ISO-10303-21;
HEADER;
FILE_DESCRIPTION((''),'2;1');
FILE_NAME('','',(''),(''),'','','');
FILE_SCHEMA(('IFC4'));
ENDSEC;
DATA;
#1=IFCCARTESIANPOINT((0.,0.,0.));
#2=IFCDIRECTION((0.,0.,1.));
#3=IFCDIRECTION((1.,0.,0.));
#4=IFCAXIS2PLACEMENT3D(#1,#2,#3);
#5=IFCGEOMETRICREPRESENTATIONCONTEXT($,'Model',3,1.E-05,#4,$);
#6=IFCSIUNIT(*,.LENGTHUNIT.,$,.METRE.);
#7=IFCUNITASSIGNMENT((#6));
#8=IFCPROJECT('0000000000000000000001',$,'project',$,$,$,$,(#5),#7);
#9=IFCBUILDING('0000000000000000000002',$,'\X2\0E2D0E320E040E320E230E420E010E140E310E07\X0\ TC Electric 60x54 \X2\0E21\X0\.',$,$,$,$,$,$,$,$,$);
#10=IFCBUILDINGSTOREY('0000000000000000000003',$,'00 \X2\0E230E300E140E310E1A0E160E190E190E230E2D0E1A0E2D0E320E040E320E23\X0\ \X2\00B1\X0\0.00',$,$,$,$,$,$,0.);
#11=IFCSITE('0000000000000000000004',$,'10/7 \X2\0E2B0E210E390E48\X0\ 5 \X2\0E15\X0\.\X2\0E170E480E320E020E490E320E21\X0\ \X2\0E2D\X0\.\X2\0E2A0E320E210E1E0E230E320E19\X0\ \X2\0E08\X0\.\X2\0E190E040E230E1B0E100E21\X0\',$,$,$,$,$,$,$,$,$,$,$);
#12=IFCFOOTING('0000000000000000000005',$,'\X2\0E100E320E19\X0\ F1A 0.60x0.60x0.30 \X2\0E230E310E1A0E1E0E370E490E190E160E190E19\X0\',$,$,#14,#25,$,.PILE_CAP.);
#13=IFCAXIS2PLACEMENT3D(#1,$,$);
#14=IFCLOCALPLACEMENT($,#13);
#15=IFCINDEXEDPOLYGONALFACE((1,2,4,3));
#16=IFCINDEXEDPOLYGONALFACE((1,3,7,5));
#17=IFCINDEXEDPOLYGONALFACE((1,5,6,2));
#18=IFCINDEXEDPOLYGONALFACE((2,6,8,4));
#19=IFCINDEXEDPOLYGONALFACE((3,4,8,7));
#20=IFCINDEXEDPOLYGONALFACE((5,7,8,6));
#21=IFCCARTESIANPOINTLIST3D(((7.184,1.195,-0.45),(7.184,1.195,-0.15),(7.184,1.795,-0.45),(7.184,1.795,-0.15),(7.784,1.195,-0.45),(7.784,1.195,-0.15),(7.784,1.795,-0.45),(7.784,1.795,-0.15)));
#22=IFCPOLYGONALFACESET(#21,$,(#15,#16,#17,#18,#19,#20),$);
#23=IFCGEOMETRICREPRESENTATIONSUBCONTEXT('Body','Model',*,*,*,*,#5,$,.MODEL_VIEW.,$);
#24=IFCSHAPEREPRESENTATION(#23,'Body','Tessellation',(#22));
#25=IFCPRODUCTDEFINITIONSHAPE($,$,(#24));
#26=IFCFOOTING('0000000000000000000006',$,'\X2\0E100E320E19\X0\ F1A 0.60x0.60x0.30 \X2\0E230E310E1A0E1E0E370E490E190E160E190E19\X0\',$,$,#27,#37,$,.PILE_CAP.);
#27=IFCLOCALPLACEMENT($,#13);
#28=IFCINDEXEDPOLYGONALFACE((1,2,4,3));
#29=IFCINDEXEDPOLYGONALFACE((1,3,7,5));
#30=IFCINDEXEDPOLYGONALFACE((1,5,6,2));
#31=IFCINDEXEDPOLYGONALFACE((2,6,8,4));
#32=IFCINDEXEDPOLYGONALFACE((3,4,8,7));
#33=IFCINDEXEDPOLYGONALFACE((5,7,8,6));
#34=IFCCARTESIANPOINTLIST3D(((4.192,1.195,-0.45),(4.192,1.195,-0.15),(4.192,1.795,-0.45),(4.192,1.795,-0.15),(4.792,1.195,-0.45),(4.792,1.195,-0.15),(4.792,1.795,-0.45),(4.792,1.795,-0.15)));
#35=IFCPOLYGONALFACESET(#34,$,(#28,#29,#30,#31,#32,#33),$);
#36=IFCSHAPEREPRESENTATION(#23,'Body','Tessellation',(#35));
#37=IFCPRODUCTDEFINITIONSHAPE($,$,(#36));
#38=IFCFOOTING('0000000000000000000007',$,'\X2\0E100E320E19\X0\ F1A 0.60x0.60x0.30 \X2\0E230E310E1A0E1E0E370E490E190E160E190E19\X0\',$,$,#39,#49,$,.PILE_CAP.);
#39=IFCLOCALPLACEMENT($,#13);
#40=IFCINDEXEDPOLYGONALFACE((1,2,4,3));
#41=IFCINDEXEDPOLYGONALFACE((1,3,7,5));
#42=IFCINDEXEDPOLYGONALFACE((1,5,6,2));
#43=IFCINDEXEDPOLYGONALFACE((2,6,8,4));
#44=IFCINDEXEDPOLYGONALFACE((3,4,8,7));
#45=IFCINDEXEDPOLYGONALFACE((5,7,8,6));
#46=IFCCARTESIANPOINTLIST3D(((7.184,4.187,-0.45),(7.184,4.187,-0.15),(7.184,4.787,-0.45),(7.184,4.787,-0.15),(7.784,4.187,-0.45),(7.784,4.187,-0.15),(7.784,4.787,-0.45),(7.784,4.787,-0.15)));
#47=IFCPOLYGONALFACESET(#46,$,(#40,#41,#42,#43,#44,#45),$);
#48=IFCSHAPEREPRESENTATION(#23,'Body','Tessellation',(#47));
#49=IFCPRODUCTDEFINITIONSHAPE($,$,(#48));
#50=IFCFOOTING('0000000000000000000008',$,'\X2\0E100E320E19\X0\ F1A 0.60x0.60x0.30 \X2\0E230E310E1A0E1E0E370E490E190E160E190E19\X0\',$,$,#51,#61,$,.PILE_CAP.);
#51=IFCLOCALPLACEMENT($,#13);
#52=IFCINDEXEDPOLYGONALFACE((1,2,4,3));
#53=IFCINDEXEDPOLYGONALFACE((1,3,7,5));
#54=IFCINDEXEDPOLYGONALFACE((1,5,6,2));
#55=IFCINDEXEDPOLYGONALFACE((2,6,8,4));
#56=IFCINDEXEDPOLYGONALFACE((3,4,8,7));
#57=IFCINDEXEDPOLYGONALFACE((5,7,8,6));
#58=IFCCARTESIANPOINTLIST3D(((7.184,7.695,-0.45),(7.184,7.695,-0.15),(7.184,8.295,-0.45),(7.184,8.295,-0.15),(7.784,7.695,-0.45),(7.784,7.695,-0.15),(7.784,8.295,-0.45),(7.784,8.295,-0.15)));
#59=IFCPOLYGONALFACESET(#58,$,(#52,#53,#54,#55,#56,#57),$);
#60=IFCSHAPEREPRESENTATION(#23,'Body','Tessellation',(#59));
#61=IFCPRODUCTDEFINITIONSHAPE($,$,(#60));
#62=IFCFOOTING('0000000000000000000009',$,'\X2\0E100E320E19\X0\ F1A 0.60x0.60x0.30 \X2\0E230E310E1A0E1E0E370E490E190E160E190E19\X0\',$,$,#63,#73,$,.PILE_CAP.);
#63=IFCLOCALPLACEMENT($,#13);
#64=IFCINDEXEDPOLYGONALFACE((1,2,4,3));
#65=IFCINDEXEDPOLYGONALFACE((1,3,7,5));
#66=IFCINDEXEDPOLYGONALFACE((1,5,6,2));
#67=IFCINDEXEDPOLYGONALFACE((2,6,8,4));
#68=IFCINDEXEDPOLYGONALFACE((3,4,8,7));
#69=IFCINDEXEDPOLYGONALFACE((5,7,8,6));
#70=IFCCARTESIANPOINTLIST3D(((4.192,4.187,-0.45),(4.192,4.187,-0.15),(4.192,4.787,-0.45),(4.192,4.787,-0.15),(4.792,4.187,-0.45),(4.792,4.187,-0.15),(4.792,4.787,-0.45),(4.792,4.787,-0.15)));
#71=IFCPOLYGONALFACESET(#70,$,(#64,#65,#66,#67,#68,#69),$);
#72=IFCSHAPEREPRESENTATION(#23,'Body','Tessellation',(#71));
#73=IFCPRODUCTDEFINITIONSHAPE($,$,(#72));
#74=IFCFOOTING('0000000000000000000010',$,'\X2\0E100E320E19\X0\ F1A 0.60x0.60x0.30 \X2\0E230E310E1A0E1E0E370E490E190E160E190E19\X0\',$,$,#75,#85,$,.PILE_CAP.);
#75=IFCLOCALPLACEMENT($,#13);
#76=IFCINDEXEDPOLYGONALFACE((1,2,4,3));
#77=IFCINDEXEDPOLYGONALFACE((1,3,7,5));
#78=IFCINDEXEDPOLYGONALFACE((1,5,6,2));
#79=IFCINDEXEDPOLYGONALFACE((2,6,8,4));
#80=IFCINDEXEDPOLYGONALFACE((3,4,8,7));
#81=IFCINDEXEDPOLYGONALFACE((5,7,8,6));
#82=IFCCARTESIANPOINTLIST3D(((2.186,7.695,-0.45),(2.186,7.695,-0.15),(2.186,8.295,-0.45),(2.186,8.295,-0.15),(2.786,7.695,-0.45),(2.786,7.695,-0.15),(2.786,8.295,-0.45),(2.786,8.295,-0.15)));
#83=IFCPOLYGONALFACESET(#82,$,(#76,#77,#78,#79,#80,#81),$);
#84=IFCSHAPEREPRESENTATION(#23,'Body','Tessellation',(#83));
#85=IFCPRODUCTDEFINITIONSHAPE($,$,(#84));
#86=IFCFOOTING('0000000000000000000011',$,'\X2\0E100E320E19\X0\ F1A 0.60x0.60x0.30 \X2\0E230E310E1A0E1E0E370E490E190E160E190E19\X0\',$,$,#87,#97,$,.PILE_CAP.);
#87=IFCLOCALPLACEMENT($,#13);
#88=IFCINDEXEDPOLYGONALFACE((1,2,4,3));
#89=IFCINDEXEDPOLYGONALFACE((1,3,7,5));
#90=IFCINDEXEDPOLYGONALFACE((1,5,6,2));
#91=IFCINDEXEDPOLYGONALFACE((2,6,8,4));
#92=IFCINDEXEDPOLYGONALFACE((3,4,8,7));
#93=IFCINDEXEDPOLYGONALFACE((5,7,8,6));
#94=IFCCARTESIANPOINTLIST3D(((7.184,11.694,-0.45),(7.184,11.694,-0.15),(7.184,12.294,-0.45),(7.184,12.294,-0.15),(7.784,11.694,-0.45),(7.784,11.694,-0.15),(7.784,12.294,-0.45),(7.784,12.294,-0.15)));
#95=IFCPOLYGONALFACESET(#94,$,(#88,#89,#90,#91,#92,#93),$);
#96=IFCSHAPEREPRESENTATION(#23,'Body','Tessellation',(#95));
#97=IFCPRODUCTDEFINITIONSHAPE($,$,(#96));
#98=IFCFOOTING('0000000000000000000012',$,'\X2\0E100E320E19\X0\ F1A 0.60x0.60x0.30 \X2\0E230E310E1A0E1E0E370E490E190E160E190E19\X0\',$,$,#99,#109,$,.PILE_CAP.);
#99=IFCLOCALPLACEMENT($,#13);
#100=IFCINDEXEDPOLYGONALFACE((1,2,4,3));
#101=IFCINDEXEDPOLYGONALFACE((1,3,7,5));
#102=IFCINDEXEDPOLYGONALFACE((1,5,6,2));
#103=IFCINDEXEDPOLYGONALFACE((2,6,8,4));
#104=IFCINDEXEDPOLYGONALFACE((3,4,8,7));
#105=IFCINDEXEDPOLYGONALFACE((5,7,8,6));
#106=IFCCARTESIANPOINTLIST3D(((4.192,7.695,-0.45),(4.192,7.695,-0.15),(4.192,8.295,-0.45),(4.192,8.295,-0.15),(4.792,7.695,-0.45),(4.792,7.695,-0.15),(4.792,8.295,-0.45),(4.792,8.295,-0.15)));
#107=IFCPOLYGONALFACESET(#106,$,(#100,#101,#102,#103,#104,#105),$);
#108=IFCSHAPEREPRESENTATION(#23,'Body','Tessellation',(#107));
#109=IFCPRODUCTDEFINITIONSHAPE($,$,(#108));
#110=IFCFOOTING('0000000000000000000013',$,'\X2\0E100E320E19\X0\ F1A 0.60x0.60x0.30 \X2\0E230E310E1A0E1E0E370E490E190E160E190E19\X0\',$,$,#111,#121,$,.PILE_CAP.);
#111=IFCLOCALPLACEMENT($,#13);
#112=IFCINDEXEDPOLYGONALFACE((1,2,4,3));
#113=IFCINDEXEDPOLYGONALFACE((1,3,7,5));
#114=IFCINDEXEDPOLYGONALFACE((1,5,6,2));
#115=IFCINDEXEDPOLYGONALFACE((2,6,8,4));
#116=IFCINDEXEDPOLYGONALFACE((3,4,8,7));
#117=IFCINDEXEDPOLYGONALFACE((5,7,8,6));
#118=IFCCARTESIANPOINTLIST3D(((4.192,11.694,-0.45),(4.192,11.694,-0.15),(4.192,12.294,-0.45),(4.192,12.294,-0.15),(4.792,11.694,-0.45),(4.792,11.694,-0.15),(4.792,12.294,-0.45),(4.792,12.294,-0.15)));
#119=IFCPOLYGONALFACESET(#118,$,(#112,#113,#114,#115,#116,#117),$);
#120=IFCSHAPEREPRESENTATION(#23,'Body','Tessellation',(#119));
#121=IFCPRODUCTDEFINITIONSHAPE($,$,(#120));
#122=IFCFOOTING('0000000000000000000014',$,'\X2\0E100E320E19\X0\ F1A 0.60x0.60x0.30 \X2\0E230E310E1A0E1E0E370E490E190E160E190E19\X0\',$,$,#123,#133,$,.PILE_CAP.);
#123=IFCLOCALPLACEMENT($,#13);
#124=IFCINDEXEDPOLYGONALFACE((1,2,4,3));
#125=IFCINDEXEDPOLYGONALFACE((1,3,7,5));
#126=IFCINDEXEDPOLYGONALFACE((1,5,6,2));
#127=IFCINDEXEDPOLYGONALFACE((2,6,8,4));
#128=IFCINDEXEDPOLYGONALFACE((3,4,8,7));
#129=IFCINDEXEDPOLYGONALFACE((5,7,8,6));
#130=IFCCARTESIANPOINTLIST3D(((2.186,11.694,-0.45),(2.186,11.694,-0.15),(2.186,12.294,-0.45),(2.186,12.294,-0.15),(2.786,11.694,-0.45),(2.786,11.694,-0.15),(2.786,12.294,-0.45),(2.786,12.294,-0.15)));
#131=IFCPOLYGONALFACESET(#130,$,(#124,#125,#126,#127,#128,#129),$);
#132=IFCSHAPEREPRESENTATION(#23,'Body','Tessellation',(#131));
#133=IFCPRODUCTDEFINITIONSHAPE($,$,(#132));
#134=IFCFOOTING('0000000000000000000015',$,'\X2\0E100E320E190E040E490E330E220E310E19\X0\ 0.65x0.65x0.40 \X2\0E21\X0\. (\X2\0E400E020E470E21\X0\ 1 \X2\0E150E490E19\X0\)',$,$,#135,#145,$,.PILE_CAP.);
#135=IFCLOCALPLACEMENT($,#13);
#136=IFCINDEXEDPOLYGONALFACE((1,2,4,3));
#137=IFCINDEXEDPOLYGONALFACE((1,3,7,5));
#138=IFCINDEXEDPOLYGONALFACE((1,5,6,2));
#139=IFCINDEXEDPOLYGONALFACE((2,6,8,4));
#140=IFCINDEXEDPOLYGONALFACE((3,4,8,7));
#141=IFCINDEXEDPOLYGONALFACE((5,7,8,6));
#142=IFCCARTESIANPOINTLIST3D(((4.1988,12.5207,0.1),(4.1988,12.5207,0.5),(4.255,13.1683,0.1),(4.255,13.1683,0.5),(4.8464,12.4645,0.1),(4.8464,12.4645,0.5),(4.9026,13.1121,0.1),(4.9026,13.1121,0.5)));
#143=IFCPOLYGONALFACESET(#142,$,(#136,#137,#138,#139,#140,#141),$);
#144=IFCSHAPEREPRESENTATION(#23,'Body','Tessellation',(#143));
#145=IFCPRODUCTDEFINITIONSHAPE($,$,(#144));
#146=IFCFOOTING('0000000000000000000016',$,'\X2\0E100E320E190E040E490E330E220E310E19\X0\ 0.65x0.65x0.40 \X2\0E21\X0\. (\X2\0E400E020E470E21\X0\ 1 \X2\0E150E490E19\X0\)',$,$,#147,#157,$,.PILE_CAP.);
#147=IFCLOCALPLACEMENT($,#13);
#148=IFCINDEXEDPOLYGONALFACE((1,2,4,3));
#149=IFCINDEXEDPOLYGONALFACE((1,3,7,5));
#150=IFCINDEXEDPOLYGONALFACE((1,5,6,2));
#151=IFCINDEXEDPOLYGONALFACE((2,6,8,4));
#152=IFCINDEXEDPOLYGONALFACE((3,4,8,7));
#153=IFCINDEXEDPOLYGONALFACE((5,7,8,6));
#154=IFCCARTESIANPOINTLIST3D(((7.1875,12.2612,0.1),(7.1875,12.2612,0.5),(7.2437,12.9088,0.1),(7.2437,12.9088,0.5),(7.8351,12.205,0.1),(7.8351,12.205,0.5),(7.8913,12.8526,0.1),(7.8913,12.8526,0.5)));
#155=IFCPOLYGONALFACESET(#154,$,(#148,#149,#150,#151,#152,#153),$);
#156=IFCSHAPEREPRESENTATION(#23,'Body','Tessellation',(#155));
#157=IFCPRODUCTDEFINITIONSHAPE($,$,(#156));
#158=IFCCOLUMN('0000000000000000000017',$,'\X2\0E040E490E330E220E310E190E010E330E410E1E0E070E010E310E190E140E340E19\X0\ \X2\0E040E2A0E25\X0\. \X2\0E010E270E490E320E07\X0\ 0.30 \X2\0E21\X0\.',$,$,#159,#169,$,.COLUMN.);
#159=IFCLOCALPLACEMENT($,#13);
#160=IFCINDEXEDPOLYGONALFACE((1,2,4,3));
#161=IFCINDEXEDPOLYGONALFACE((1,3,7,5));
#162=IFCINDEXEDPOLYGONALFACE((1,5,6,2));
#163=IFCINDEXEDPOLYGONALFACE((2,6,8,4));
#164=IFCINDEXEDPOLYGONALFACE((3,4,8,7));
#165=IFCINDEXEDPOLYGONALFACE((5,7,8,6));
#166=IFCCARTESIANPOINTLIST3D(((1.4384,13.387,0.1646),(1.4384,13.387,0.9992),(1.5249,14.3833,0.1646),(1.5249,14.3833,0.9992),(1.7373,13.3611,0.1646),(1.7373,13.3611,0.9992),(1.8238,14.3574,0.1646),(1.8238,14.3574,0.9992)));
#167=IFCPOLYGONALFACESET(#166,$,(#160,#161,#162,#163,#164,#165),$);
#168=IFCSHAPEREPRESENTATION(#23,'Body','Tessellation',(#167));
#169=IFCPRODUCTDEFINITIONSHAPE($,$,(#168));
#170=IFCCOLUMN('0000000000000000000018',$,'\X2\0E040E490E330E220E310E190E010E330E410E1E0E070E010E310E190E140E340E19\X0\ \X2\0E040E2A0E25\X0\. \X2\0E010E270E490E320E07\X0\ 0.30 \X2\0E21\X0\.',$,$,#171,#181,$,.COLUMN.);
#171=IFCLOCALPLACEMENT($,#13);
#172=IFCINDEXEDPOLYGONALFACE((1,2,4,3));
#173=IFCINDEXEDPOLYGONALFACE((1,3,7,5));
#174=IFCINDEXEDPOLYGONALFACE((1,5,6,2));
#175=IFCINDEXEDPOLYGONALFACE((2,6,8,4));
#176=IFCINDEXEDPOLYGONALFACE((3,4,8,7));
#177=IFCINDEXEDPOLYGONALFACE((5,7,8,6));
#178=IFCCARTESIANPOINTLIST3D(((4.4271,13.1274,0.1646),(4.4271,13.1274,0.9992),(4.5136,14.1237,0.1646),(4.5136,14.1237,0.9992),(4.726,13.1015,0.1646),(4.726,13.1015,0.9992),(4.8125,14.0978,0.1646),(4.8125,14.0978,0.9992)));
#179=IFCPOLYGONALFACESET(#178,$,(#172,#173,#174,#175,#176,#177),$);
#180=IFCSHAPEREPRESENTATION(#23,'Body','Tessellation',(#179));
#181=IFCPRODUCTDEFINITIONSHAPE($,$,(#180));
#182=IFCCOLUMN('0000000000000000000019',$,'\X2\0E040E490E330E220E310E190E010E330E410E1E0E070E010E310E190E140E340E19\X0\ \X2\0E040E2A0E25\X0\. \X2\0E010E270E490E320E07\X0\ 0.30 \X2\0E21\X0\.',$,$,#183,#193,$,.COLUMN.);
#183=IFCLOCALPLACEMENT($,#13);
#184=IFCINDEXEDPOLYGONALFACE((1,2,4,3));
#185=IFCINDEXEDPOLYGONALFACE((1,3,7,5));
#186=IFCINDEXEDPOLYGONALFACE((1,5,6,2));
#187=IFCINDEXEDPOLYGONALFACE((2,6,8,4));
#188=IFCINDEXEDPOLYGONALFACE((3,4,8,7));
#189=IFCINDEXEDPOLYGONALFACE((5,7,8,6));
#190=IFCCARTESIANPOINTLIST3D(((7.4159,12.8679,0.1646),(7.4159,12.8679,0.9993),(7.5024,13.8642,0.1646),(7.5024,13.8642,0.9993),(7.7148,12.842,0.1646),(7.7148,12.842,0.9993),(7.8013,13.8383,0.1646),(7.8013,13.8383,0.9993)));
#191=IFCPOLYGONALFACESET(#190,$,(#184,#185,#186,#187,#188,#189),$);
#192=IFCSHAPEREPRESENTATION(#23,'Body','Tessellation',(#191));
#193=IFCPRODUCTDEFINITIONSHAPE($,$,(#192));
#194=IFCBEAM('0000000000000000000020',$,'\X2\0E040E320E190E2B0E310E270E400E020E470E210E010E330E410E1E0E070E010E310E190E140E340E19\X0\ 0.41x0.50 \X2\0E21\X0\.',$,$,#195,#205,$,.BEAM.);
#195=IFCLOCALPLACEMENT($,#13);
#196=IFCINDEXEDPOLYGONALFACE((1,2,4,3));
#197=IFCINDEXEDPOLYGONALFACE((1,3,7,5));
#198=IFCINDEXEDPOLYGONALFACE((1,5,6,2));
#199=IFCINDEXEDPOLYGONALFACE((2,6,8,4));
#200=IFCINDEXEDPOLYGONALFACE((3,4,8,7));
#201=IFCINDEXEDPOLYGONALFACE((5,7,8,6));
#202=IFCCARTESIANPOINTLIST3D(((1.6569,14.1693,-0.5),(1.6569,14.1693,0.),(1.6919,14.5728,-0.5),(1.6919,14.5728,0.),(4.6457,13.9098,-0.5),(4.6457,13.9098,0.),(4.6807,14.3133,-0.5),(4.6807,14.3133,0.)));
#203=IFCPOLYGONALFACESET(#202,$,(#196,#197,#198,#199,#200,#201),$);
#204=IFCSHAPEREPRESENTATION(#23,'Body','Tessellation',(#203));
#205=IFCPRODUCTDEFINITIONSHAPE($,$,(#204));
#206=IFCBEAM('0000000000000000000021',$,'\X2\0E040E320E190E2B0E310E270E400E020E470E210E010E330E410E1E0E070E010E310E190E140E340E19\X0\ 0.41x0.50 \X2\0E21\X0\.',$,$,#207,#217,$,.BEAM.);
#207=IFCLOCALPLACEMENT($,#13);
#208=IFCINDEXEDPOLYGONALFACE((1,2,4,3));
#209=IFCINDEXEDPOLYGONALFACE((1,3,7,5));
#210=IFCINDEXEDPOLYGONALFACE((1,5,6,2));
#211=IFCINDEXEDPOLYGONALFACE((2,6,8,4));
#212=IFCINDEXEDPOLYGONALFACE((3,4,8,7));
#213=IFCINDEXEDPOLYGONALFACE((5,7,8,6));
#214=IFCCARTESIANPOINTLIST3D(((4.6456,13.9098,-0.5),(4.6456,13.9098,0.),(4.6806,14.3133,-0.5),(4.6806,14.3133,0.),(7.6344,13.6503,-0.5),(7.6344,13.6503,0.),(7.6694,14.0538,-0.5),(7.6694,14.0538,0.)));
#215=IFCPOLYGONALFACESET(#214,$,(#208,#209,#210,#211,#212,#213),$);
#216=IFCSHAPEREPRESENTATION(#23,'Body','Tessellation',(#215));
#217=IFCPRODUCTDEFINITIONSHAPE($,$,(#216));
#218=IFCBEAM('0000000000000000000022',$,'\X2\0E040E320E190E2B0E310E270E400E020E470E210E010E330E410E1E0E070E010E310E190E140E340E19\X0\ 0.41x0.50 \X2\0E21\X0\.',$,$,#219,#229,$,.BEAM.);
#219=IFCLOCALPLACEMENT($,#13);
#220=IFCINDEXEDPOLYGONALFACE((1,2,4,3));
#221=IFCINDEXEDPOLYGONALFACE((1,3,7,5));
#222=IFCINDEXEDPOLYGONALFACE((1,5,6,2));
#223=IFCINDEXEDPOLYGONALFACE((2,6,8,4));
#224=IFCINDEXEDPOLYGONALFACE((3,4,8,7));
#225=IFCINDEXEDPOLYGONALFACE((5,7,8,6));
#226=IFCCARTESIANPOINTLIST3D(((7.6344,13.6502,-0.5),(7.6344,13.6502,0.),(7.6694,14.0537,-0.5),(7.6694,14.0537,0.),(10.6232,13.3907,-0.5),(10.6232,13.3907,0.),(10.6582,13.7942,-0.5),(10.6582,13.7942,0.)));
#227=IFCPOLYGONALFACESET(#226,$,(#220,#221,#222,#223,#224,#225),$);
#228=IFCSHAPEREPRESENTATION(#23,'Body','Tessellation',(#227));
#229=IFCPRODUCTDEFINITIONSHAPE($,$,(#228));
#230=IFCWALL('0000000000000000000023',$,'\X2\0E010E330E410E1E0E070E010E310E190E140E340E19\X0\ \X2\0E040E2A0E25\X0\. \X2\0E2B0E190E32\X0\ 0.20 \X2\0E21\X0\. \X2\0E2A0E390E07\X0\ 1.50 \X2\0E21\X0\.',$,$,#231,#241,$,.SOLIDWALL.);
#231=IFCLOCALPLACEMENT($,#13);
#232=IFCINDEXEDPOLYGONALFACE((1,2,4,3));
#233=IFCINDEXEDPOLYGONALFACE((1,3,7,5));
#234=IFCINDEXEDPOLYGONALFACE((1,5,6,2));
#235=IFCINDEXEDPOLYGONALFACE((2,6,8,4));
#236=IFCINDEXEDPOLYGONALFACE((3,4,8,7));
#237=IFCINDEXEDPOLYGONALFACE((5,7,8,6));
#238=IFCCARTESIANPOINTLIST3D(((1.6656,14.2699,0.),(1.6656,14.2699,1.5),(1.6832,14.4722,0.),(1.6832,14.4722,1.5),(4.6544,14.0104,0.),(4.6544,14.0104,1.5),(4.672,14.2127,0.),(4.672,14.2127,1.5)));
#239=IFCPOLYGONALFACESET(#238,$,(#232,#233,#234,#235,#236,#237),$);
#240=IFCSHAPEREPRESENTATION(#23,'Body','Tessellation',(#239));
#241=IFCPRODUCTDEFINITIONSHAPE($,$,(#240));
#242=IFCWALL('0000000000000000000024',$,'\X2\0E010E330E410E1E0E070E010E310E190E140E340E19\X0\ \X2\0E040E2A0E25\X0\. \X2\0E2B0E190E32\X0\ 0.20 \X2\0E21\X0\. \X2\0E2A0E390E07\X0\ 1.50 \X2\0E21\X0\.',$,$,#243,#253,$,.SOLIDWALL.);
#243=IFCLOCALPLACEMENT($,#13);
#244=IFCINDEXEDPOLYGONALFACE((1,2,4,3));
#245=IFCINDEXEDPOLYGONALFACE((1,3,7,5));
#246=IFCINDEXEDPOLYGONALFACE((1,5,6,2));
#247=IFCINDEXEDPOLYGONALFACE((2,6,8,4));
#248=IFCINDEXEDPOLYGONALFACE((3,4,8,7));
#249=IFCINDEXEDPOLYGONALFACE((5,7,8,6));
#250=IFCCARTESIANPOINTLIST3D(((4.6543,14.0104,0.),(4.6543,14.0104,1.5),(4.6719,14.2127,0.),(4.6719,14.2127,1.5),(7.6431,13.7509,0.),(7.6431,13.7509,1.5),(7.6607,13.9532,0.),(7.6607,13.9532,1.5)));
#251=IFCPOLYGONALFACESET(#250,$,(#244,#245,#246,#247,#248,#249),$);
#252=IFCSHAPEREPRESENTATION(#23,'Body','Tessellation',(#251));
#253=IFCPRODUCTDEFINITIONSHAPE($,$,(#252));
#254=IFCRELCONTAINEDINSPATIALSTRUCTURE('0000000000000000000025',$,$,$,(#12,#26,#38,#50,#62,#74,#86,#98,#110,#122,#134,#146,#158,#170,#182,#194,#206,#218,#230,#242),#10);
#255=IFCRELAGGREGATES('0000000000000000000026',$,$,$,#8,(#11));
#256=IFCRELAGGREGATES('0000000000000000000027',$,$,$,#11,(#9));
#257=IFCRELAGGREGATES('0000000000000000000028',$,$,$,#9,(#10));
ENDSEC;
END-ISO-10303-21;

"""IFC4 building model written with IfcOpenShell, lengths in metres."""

from ifc_helpers import new_model, si_unit, frame, origin, origin_with_axes, origin_2d, place, context, subcontext, project, spatial, rectangle, extrude, element, save


model = new_model("IFC4")

# Units and contexts
model_context = context("Model", 3, precision=1e-05, world=origin_with_axes())
body_context = subcontext(model_context, "Body", "Model", "MODEL_VIEW")
ifc_project = project(units=[si_unit("LENGTHUNIT", "METRE")], contexts=[model_context])

# Site, building, storey
site = spatial("IfcSite", under=ifc_project, Name="10/7 หมู่ 5 ต.ท่าข้าม อ.สามพราน จ.นครปฐม")
building = spatial("IfcBuilding", under=site, Name="อาคารโกดัง TC Electric 60x54 ม.")
storey = spatial("IfcBuildingStorey", under=building, Name="00 ระดับถนนรอบอาคาร ±0.00", Elevation=0.0)

# Footings
for number, where, z_axis, x_axis, name in (
    (1, (7.484, 1.495, -0.45), (0.0, 0.0, 1.0), (1.0, 0.0, 0.0), "ฐาน F1A 0.60x0.60x0.30 รับพื้นถนน"),
    (2, (4.492, 1.495, -0.45), (0.0, 0.0, 1.0), (1.0, 0.0, 0.0), "ฐาน F1A 0.60x0.60x0.30 รับพื้นถนน"),
    (3, (7.484, 4.487, -0.45), (0.0, 0.0, 1.0), (1.0, 0.0, 0.0), "ฐาน F1A 0.60x0.60x0.30 รับพื้นถนน"),
    (4, (7.484, 7.995, -0.45), (0.0, 0.0, 1.0), (1.0, 0.0, 0.0), "ฐาน F1A 0.60x0.60x0.30 รับพื้นถนน"),
    (5, (4.492, 4.487, -0.45), (0.0, 0.0, 1.0), (1.0, 0.0, 0.0), "ฐาน F1A 0.60x0.60x0.30 รับพื้นถนน"),
    (6, (2.486, 7.995, -0.45), (0.0, 0.0, 1.0), (1.0, 0.0, 0.0), "ฐาน F1A 0.60x0.60x0.30 รับพื้นถนน"),
    (7, (7.484, 11.994, -0.45), (0.0, 0.0, 1.0), (1.0, 0.0, 0.0), "ฐาน F1A 0.60x0.60x0.30 รับพื้นถนน"),
    (8, (4.492, 7.995, -0.45), (0.0, 0.0, 1.0), (1.0, 0.0, 0.0), "ฐาน F1A 0.60x0.60x0.30 รับพื้นถนน"),
    (9, (4.492, 11.994, -0.45), (0.0, 0.0, 1.0), (1.0, 0.0, 0.0), "ฐาน F1A 0.60x0.60x0.30 รับพื้นถนน"),
    (10, (2.486, 11.994, -0.45), (0.0, 0.0, 1.0), (1.0, 0.0, 0.0), "ฐาน F1A 0.60x0.60x0.30 รับพื้นถนน"),
):
    element("IfcFooting", number, at=place(None, frame(where, z_axis=z_axis, x_axis=x_axis)), inside=storey, Name=name, PredefinedType="PILE_CAP", context=body_context, shape_type="SweptSolid", body=[
        extrude(rectangle(XDim=0.6, YDim=0.6, at=origin_2d()), origin(), (0.0, 0.0, 1.0), 0.3),
    ])
for number, where, z_axis, x_axis, name in (
    (11, (4.5507, 12.8164, 0.1), (0.0, 0.0, 1.0), (-0.0865, -0.9962, 0.0), "ฐานค้ำยัน 0.65x0.65x0.40 ม. (เข็ม 1 ต้น)"),
    (12, (7.5394, 12.5569, 0.1), (0.0, 0.0, 1.0), (-0.0865, -0.9962, 0.0), "ฐานค้ำยัน 0.65x0.65x0.40 ม. (เข็ม 1 ต้น)"),
):
    element("IfcFooting", number, at=place(None, frame(where, z_axis=z_axis, x_axis=x_axis)), inside=storey, Name=name, PredefinedType="PILE_CAP", context=body_context, shape_type="SweptSolid", body=[
        extrude(rectangle(XDim=0.65, YDim=0.65, at=origin_2d()), origin(), (0.0, 0.0, 1.0), 0.4),
    ])

# Columns
for number, where, z_axis, x_axis, name in (
    (13, (1.6311, 13.8722, 0.1646), (0.0, 0.0, 1.0), (-0.0865, -0.9962, 0.0), "ค้ำยันกำแพงกันดิน คสล. กว้าง 0.30 ม."),
    (14, (4.6198, 13.6126, 0.1646), (0.0, 0.0, 1.0), (-0.0865, -0.9962, 0.0), "ค้ำยันกำแพงกันดิน คสล. กว้าง 0.30 ม."),
):
    element("IfcColumn", number, at=place(None, frame(where, z_axis=z_axis, x_axis=x_axis)), inside=storey, Name=name, PredefinedType="COLUMN", context=body_context, shape_type="SweptSolid", body=[
        extrude(rectangle(XDim=1.0, YDim=0.3, at=origin_2d()), origin(), (0.0, 0.0, 1.0), 0.8346),
    ])
column_placement = place(None, frame((7.6086, 13.3531, 0.1646), z_axis=(0.0, 0.0, 1.0), x_axis=(-0.0865, -0.9962, 0.0)))
element("IfcColumn", 15, at=column_placement, inside=storey, Name="ค้ำยันกำแพงกันดิน คสล. กว้าง 0.30 ม.", PredefinedType="COLUMN", context=body_context, shape_type="SweptSolid", body=[
    extrude(rectangle(XDim=1.0, YDim=0.3, at=origin_2d()), origin(), (0.0, 0.0, 1.0), 0.8347),
])

# Beams
for number, where, z_axis, x_axis, name in (
    (16, (3.1688, 14.2413, -0.5), (0.0, 0.0, 1.0), (0.9962, -0.0865, 0.0), "คานหัวเข็มกำแพงกันดิน 0.41x0.50 ม."),
    (17, (6.1575, 13.9818, -0.5), (0.0, 0.0, 1.0), (0.9962, -0.0865, 0.0), "คานหัวเข็มกำแพงกันดิน 0.41x0.50 ม."),
    (18, (9.1463, 13.7222, -0.5), (0.0, 0.0, 1.0), (0.9962, -0.0865, 0.0), "คานหัวเข็มกำแพงกันดิน 0.41x0.50 ม."),
):
    element("IfcBeam", number, at=place(None, frame(where, z_axis=z_axis, x_axis=x_axis)), inside=storey, Name=name, PredefinedType="BEAM", context=body_context, shape_type="SweptSolid", body=[
        extrude(rectangle(XDim=3.0, YDim=0.405, at=origin_2d()), origin(), (0.0, 0.0, 1.0), 0.5),
    ])

# Walls
for number, where, z_axis, x_axis, name in (
    (19, (3.1688, 14.2413, 0.0), (0.0, 0.0, 1.0), (0.9962, -0.0865, 0.0), "กำแพงกันดิน คสล. หนา 0.20 ม. สูง 1.50 ม."),
    (20, (6.1575, 13.9818, 0.0), (0.0, 0.0, 1.0), (0.9962, -0.0865, 0.0), "กำแพงกันดิน คสล. หนา 0.20 ม. สูง 1.50 ม."),
):
    element("IfcWall", number, at=place(None, frame(where, z_axis=z_axis, x_axis=x_axis)), inside=storey, Name=name, PredefinedType="SOLIDWALL", context=body_context, shape_type="SweptSolid", body=[
        extrude(rectangle(XDim=3.0, YDim=0.203, at=origin_2d()), origin(), (0.0, 0.0, 1.0), 1.5),
    ])

save(model, "model.ifc")
